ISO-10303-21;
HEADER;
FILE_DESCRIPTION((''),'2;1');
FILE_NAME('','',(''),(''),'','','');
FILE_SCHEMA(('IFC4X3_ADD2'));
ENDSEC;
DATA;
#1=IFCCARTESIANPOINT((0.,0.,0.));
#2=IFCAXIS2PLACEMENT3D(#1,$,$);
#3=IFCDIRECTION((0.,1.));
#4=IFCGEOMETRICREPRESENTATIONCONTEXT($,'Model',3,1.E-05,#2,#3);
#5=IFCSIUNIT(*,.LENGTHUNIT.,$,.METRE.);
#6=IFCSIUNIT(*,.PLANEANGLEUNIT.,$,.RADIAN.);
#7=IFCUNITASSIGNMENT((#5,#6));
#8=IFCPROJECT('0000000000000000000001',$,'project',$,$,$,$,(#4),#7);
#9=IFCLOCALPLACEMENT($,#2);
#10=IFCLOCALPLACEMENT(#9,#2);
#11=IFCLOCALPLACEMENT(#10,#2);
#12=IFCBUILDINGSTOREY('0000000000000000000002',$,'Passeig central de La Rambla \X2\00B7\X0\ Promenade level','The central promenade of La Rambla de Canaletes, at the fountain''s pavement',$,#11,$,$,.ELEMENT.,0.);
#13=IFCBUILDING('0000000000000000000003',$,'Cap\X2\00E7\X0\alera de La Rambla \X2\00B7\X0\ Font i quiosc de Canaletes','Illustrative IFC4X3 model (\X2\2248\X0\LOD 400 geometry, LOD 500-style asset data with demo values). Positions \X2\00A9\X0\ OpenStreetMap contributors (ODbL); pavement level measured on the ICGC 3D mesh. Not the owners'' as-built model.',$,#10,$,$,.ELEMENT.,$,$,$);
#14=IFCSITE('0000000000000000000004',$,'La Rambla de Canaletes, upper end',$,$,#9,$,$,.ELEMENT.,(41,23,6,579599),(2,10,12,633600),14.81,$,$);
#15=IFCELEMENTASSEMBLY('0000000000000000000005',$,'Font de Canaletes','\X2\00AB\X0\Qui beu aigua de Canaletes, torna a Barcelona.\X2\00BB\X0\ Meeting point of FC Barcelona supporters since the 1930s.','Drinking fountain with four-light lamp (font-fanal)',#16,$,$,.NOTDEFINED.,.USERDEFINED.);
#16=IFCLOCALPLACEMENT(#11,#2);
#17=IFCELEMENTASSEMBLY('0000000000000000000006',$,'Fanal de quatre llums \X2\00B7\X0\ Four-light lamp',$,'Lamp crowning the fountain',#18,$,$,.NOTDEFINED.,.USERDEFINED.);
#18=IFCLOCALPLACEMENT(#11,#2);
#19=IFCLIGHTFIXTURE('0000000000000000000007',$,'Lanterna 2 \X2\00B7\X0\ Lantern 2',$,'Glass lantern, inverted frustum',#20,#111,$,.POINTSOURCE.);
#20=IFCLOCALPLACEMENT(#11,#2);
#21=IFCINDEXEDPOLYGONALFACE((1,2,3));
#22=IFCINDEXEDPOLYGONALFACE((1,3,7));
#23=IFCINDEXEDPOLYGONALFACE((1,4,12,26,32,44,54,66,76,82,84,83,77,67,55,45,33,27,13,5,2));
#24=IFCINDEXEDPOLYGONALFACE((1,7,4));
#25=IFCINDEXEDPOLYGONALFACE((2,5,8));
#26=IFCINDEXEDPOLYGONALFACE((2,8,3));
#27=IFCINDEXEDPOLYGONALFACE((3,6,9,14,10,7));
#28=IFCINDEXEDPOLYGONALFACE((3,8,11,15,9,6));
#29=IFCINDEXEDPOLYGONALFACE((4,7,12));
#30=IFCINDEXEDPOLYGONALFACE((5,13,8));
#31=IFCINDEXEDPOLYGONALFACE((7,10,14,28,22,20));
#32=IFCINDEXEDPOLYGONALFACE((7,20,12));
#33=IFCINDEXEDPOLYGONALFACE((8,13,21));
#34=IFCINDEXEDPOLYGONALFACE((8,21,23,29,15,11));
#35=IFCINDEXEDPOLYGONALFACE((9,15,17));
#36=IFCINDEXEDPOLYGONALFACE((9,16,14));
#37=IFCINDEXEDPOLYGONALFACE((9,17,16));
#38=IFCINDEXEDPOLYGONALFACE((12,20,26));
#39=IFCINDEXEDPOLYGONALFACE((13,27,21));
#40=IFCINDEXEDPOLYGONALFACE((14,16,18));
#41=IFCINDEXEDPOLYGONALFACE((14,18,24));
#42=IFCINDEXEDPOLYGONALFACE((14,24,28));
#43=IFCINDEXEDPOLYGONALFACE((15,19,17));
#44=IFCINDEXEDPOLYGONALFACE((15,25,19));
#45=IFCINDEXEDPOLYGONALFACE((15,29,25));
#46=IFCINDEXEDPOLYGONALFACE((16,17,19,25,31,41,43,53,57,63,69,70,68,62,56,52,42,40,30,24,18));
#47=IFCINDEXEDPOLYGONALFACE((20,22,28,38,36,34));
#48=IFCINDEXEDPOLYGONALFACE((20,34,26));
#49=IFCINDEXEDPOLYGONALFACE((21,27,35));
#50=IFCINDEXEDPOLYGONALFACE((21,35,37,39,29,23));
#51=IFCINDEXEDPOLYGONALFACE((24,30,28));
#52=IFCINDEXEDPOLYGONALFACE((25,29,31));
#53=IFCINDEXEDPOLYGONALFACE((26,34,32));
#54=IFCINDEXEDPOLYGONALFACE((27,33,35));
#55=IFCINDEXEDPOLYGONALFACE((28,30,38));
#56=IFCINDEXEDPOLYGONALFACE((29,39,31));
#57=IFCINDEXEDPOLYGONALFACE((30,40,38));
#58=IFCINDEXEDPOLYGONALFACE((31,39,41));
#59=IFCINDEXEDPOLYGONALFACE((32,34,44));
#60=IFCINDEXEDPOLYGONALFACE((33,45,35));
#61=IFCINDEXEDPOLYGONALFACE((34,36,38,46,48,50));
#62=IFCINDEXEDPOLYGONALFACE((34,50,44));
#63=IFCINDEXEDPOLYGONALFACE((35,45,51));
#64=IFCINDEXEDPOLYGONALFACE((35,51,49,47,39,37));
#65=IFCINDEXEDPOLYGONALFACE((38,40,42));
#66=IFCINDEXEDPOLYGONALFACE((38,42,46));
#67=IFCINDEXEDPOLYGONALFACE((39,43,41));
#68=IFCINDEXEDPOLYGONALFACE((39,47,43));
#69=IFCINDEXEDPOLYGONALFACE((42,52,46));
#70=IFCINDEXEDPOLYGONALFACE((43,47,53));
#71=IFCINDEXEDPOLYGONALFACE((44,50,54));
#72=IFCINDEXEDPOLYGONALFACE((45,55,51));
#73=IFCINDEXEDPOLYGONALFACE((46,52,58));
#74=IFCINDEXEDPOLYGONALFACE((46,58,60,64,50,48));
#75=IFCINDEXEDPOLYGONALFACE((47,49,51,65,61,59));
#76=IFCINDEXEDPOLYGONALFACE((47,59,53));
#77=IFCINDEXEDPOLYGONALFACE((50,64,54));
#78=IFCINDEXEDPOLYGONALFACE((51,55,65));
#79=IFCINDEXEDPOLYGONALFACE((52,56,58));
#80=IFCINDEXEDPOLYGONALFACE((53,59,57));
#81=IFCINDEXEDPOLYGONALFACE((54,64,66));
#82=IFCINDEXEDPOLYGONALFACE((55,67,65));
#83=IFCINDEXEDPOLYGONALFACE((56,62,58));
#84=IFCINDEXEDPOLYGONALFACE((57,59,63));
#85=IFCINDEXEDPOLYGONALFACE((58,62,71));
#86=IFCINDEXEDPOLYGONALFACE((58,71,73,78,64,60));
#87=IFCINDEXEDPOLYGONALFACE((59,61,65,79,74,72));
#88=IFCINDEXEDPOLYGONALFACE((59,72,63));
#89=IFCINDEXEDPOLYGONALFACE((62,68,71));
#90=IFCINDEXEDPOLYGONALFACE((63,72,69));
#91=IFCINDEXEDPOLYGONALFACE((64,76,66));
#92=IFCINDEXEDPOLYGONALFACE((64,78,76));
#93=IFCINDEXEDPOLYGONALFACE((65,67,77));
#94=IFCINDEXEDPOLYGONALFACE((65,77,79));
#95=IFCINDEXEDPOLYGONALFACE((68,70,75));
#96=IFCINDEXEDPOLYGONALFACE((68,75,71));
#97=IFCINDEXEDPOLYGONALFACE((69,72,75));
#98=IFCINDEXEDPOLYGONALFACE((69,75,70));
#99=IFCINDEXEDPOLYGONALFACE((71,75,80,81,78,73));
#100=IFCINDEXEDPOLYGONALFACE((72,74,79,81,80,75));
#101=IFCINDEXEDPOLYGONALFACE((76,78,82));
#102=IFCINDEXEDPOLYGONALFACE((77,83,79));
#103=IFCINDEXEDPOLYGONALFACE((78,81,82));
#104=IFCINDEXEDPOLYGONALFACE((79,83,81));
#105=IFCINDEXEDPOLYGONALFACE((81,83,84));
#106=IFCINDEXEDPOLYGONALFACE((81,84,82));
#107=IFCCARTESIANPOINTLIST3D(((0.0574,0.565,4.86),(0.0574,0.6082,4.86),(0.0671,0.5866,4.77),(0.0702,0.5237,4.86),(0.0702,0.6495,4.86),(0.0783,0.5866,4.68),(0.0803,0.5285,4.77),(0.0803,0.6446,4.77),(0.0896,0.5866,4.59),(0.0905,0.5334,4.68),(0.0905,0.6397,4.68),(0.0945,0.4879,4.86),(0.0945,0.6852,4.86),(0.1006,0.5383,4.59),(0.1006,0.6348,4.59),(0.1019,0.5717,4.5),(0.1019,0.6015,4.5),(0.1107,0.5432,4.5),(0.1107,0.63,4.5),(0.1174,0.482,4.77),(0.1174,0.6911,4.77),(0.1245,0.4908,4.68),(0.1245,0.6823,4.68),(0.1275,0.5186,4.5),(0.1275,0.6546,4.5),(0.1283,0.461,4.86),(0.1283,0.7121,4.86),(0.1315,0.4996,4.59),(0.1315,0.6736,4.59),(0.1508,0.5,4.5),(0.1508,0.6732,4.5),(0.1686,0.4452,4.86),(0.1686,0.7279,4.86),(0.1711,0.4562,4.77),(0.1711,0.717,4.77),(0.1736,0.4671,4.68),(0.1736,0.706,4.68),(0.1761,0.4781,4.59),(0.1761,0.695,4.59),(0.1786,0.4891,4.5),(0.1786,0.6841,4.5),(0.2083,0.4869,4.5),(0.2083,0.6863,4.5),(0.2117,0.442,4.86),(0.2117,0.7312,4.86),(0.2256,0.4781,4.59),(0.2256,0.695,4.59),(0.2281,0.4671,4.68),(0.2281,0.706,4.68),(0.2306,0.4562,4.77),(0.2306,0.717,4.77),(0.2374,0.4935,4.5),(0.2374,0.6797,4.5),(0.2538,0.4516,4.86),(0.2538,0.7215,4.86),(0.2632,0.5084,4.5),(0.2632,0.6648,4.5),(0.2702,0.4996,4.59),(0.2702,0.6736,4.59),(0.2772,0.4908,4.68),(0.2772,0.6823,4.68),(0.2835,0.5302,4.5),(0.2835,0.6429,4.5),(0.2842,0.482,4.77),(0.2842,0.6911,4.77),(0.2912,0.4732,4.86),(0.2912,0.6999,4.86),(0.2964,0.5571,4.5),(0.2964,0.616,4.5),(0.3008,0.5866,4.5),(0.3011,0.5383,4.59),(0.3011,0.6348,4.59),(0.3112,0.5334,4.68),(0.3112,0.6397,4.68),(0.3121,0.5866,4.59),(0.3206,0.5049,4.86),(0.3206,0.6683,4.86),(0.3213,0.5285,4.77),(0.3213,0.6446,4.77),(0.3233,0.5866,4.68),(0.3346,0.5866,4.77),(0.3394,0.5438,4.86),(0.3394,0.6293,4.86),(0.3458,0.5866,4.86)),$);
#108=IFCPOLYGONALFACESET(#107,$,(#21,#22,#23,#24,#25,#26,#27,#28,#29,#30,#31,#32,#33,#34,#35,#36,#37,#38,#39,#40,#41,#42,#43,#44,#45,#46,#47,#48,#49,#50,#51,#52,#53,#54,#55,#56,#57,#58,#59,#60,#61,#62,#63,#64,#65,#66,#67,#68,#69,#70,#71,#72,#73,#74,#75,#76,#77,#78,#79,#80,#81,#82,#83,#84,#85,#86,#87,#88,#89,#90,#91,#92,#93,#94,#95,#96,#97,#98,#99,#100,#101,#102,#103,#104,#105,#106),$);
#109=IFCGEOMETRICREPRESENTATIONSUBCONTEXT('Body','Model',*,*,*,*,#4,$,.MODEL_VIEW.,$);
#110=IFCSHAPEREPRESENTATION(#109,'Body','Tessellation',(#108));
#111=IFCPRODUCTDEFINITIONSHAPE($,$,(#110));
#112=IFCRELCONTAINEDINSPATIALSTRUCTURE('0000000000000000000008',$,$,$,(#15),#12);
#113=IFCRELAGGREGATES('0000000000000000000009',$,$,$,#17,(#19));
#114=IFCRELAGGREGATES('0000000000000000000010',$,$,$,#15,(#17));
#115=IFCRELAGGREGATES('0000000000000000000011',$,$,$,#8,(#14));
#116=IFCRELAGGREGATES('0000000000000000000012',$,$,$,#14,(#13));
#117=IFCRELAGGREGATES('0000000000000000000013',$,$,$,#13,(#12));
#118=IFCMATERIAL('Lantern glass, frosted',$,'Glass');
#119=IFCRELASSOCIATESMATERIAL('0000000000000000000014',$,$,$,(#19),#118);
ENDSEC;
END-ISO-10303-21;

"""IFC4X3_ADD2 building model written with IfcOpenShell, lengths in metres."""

from ifc_helpers import new_model, entity, si_unit, direction, origin, place, context, subcontext, project, spatial, material, element, aggregate, save


model = new_model("IFC4X3_ADD2")

# Units and contexts
model_context = context("Model", 3, precision=1e-05, world=origin(), true_north=direction((0.0, 1.0)))
body_context = subcontext(model_context, "Body", "Model", "MODEL_VIEW")
ifc_project = project(units=[si_unit("LENGTHUNIT", "METRE"), si_unit("PLANEANGLEUNIT", "RADIAN")], contexts=[model_context])

# Site, building, storey
site_placement = place(None, origin())
site = spatial("IfcSite", under=ifc_project, at=site_placement, Name="La Rambla de Canaletes, upper end", CompositionType="ELEMENT", RefLatitude=(41, 23, 6, 579599), RefLongitude=(2, 10, 12, 633600), RefElevation=14.81)
building_placement = place(site_placement, origin())
building = spatial("IfcBuilding", under=site, at=building_placement, Name="Capçalera de La Rambla · Font i quiosc de Canaletes", Description="Illustrative IFC4X3 model (≈LOD 400 geometry, LOD 500-style asset data with demo values). Positions © OpenStreetMap contributors (ODbL); pavement level measured on the ICGC 3D mesh. Not the owners' as-built model.", CompositionType="ELEMENT")
storey_placement = place(building_placement, origin())
storey = spatial("IfcBuildingStorey", under=building, at=storey_placement, Name="Passeig central de La Rambla · Promenade level", Description="The central promenade of La Rambla de Canaletes, at the fountain's pavement", CompositionType="ELEMENT", Elevation=0.0)

# Element assemblies, light fixture
assembly_1_placement = place(building_placement, origin())
assembly_1 = element("IfcElementAssembly", 1, at=assembly_1_placement, inside=storey, Name="Font de Canaletes", Description="«Qui beu aigua de Canaletes, torna a Barcelona.» Meeting point of FC Barcelona supporters since the 1930s.", ObjectType="Drinking fountain with four-light lamp (font-fanal)", AssemblyPlace="NOTDEFINED", PredefinedType="USERDEFINED")
assembly_2_placement = place(building_placement, origin())
assembly_2 = element("IfcElementAssembly", 2, at=assembly_2_placement, Name="Fanal de quatre llums · Four-light lamp", ObjectType="Lamp crowning the fountain", AssemblyPlace="NOTDEFINED", PredefinedType="USERDEFINED")
ifc_material_1 = material(Name="Lantern glass, frosted", Category="Glass")
light_fixture_1_placement = place(building_placement, origin())
light_fixture_1 = element("IfcLightFixture", 3, at=light_fixture_1_placement, material=ifc_material_1, Name="Lanterna 2 · Lantern 2", ObjectType="Glass lantern, inverted frustum", PredefinedType="POINTSOURCE", context=body_context, shape_type="SweptSolid", body=[
    entity("IfcRevolvedAreaSolid", entity("IfcArbitraryClosedProfileDef", "AREA", None, entity("IfcPolyline", [entity("IfcCartesianPoint", [0.0, 0.0]), entity("IfcCartesianPoint", [0.1, 0.0]), entity("IfcCartesianPoint", [0.145, 0.36]), entity("IfcCartesianPoint", [0.0, 0.36]), entity("IfcCartesianPoint", [0.0, 0.0])])), entity("IfcAxis2Placement3D", entity("IfcCartesianPoint", [0.2008, 0.5866, 4.5]), entity("IfcDirection", [0.0, -1.0, 0.0]), entity("IfcDirection", [1.0, 0.0, 0.0])), entity("IfcAxis1Placement", entity("IfcCartesianPoint", [0.0, 0.0, 0.0]), entity("IfcDirection", [0.0, 1.0, 0.0])), 6.283185),
])
aggregate(assembly_2, [light_fixture_1])
aggregate(assembly_1, [assembly_2])

save(model, "model.ifc")
